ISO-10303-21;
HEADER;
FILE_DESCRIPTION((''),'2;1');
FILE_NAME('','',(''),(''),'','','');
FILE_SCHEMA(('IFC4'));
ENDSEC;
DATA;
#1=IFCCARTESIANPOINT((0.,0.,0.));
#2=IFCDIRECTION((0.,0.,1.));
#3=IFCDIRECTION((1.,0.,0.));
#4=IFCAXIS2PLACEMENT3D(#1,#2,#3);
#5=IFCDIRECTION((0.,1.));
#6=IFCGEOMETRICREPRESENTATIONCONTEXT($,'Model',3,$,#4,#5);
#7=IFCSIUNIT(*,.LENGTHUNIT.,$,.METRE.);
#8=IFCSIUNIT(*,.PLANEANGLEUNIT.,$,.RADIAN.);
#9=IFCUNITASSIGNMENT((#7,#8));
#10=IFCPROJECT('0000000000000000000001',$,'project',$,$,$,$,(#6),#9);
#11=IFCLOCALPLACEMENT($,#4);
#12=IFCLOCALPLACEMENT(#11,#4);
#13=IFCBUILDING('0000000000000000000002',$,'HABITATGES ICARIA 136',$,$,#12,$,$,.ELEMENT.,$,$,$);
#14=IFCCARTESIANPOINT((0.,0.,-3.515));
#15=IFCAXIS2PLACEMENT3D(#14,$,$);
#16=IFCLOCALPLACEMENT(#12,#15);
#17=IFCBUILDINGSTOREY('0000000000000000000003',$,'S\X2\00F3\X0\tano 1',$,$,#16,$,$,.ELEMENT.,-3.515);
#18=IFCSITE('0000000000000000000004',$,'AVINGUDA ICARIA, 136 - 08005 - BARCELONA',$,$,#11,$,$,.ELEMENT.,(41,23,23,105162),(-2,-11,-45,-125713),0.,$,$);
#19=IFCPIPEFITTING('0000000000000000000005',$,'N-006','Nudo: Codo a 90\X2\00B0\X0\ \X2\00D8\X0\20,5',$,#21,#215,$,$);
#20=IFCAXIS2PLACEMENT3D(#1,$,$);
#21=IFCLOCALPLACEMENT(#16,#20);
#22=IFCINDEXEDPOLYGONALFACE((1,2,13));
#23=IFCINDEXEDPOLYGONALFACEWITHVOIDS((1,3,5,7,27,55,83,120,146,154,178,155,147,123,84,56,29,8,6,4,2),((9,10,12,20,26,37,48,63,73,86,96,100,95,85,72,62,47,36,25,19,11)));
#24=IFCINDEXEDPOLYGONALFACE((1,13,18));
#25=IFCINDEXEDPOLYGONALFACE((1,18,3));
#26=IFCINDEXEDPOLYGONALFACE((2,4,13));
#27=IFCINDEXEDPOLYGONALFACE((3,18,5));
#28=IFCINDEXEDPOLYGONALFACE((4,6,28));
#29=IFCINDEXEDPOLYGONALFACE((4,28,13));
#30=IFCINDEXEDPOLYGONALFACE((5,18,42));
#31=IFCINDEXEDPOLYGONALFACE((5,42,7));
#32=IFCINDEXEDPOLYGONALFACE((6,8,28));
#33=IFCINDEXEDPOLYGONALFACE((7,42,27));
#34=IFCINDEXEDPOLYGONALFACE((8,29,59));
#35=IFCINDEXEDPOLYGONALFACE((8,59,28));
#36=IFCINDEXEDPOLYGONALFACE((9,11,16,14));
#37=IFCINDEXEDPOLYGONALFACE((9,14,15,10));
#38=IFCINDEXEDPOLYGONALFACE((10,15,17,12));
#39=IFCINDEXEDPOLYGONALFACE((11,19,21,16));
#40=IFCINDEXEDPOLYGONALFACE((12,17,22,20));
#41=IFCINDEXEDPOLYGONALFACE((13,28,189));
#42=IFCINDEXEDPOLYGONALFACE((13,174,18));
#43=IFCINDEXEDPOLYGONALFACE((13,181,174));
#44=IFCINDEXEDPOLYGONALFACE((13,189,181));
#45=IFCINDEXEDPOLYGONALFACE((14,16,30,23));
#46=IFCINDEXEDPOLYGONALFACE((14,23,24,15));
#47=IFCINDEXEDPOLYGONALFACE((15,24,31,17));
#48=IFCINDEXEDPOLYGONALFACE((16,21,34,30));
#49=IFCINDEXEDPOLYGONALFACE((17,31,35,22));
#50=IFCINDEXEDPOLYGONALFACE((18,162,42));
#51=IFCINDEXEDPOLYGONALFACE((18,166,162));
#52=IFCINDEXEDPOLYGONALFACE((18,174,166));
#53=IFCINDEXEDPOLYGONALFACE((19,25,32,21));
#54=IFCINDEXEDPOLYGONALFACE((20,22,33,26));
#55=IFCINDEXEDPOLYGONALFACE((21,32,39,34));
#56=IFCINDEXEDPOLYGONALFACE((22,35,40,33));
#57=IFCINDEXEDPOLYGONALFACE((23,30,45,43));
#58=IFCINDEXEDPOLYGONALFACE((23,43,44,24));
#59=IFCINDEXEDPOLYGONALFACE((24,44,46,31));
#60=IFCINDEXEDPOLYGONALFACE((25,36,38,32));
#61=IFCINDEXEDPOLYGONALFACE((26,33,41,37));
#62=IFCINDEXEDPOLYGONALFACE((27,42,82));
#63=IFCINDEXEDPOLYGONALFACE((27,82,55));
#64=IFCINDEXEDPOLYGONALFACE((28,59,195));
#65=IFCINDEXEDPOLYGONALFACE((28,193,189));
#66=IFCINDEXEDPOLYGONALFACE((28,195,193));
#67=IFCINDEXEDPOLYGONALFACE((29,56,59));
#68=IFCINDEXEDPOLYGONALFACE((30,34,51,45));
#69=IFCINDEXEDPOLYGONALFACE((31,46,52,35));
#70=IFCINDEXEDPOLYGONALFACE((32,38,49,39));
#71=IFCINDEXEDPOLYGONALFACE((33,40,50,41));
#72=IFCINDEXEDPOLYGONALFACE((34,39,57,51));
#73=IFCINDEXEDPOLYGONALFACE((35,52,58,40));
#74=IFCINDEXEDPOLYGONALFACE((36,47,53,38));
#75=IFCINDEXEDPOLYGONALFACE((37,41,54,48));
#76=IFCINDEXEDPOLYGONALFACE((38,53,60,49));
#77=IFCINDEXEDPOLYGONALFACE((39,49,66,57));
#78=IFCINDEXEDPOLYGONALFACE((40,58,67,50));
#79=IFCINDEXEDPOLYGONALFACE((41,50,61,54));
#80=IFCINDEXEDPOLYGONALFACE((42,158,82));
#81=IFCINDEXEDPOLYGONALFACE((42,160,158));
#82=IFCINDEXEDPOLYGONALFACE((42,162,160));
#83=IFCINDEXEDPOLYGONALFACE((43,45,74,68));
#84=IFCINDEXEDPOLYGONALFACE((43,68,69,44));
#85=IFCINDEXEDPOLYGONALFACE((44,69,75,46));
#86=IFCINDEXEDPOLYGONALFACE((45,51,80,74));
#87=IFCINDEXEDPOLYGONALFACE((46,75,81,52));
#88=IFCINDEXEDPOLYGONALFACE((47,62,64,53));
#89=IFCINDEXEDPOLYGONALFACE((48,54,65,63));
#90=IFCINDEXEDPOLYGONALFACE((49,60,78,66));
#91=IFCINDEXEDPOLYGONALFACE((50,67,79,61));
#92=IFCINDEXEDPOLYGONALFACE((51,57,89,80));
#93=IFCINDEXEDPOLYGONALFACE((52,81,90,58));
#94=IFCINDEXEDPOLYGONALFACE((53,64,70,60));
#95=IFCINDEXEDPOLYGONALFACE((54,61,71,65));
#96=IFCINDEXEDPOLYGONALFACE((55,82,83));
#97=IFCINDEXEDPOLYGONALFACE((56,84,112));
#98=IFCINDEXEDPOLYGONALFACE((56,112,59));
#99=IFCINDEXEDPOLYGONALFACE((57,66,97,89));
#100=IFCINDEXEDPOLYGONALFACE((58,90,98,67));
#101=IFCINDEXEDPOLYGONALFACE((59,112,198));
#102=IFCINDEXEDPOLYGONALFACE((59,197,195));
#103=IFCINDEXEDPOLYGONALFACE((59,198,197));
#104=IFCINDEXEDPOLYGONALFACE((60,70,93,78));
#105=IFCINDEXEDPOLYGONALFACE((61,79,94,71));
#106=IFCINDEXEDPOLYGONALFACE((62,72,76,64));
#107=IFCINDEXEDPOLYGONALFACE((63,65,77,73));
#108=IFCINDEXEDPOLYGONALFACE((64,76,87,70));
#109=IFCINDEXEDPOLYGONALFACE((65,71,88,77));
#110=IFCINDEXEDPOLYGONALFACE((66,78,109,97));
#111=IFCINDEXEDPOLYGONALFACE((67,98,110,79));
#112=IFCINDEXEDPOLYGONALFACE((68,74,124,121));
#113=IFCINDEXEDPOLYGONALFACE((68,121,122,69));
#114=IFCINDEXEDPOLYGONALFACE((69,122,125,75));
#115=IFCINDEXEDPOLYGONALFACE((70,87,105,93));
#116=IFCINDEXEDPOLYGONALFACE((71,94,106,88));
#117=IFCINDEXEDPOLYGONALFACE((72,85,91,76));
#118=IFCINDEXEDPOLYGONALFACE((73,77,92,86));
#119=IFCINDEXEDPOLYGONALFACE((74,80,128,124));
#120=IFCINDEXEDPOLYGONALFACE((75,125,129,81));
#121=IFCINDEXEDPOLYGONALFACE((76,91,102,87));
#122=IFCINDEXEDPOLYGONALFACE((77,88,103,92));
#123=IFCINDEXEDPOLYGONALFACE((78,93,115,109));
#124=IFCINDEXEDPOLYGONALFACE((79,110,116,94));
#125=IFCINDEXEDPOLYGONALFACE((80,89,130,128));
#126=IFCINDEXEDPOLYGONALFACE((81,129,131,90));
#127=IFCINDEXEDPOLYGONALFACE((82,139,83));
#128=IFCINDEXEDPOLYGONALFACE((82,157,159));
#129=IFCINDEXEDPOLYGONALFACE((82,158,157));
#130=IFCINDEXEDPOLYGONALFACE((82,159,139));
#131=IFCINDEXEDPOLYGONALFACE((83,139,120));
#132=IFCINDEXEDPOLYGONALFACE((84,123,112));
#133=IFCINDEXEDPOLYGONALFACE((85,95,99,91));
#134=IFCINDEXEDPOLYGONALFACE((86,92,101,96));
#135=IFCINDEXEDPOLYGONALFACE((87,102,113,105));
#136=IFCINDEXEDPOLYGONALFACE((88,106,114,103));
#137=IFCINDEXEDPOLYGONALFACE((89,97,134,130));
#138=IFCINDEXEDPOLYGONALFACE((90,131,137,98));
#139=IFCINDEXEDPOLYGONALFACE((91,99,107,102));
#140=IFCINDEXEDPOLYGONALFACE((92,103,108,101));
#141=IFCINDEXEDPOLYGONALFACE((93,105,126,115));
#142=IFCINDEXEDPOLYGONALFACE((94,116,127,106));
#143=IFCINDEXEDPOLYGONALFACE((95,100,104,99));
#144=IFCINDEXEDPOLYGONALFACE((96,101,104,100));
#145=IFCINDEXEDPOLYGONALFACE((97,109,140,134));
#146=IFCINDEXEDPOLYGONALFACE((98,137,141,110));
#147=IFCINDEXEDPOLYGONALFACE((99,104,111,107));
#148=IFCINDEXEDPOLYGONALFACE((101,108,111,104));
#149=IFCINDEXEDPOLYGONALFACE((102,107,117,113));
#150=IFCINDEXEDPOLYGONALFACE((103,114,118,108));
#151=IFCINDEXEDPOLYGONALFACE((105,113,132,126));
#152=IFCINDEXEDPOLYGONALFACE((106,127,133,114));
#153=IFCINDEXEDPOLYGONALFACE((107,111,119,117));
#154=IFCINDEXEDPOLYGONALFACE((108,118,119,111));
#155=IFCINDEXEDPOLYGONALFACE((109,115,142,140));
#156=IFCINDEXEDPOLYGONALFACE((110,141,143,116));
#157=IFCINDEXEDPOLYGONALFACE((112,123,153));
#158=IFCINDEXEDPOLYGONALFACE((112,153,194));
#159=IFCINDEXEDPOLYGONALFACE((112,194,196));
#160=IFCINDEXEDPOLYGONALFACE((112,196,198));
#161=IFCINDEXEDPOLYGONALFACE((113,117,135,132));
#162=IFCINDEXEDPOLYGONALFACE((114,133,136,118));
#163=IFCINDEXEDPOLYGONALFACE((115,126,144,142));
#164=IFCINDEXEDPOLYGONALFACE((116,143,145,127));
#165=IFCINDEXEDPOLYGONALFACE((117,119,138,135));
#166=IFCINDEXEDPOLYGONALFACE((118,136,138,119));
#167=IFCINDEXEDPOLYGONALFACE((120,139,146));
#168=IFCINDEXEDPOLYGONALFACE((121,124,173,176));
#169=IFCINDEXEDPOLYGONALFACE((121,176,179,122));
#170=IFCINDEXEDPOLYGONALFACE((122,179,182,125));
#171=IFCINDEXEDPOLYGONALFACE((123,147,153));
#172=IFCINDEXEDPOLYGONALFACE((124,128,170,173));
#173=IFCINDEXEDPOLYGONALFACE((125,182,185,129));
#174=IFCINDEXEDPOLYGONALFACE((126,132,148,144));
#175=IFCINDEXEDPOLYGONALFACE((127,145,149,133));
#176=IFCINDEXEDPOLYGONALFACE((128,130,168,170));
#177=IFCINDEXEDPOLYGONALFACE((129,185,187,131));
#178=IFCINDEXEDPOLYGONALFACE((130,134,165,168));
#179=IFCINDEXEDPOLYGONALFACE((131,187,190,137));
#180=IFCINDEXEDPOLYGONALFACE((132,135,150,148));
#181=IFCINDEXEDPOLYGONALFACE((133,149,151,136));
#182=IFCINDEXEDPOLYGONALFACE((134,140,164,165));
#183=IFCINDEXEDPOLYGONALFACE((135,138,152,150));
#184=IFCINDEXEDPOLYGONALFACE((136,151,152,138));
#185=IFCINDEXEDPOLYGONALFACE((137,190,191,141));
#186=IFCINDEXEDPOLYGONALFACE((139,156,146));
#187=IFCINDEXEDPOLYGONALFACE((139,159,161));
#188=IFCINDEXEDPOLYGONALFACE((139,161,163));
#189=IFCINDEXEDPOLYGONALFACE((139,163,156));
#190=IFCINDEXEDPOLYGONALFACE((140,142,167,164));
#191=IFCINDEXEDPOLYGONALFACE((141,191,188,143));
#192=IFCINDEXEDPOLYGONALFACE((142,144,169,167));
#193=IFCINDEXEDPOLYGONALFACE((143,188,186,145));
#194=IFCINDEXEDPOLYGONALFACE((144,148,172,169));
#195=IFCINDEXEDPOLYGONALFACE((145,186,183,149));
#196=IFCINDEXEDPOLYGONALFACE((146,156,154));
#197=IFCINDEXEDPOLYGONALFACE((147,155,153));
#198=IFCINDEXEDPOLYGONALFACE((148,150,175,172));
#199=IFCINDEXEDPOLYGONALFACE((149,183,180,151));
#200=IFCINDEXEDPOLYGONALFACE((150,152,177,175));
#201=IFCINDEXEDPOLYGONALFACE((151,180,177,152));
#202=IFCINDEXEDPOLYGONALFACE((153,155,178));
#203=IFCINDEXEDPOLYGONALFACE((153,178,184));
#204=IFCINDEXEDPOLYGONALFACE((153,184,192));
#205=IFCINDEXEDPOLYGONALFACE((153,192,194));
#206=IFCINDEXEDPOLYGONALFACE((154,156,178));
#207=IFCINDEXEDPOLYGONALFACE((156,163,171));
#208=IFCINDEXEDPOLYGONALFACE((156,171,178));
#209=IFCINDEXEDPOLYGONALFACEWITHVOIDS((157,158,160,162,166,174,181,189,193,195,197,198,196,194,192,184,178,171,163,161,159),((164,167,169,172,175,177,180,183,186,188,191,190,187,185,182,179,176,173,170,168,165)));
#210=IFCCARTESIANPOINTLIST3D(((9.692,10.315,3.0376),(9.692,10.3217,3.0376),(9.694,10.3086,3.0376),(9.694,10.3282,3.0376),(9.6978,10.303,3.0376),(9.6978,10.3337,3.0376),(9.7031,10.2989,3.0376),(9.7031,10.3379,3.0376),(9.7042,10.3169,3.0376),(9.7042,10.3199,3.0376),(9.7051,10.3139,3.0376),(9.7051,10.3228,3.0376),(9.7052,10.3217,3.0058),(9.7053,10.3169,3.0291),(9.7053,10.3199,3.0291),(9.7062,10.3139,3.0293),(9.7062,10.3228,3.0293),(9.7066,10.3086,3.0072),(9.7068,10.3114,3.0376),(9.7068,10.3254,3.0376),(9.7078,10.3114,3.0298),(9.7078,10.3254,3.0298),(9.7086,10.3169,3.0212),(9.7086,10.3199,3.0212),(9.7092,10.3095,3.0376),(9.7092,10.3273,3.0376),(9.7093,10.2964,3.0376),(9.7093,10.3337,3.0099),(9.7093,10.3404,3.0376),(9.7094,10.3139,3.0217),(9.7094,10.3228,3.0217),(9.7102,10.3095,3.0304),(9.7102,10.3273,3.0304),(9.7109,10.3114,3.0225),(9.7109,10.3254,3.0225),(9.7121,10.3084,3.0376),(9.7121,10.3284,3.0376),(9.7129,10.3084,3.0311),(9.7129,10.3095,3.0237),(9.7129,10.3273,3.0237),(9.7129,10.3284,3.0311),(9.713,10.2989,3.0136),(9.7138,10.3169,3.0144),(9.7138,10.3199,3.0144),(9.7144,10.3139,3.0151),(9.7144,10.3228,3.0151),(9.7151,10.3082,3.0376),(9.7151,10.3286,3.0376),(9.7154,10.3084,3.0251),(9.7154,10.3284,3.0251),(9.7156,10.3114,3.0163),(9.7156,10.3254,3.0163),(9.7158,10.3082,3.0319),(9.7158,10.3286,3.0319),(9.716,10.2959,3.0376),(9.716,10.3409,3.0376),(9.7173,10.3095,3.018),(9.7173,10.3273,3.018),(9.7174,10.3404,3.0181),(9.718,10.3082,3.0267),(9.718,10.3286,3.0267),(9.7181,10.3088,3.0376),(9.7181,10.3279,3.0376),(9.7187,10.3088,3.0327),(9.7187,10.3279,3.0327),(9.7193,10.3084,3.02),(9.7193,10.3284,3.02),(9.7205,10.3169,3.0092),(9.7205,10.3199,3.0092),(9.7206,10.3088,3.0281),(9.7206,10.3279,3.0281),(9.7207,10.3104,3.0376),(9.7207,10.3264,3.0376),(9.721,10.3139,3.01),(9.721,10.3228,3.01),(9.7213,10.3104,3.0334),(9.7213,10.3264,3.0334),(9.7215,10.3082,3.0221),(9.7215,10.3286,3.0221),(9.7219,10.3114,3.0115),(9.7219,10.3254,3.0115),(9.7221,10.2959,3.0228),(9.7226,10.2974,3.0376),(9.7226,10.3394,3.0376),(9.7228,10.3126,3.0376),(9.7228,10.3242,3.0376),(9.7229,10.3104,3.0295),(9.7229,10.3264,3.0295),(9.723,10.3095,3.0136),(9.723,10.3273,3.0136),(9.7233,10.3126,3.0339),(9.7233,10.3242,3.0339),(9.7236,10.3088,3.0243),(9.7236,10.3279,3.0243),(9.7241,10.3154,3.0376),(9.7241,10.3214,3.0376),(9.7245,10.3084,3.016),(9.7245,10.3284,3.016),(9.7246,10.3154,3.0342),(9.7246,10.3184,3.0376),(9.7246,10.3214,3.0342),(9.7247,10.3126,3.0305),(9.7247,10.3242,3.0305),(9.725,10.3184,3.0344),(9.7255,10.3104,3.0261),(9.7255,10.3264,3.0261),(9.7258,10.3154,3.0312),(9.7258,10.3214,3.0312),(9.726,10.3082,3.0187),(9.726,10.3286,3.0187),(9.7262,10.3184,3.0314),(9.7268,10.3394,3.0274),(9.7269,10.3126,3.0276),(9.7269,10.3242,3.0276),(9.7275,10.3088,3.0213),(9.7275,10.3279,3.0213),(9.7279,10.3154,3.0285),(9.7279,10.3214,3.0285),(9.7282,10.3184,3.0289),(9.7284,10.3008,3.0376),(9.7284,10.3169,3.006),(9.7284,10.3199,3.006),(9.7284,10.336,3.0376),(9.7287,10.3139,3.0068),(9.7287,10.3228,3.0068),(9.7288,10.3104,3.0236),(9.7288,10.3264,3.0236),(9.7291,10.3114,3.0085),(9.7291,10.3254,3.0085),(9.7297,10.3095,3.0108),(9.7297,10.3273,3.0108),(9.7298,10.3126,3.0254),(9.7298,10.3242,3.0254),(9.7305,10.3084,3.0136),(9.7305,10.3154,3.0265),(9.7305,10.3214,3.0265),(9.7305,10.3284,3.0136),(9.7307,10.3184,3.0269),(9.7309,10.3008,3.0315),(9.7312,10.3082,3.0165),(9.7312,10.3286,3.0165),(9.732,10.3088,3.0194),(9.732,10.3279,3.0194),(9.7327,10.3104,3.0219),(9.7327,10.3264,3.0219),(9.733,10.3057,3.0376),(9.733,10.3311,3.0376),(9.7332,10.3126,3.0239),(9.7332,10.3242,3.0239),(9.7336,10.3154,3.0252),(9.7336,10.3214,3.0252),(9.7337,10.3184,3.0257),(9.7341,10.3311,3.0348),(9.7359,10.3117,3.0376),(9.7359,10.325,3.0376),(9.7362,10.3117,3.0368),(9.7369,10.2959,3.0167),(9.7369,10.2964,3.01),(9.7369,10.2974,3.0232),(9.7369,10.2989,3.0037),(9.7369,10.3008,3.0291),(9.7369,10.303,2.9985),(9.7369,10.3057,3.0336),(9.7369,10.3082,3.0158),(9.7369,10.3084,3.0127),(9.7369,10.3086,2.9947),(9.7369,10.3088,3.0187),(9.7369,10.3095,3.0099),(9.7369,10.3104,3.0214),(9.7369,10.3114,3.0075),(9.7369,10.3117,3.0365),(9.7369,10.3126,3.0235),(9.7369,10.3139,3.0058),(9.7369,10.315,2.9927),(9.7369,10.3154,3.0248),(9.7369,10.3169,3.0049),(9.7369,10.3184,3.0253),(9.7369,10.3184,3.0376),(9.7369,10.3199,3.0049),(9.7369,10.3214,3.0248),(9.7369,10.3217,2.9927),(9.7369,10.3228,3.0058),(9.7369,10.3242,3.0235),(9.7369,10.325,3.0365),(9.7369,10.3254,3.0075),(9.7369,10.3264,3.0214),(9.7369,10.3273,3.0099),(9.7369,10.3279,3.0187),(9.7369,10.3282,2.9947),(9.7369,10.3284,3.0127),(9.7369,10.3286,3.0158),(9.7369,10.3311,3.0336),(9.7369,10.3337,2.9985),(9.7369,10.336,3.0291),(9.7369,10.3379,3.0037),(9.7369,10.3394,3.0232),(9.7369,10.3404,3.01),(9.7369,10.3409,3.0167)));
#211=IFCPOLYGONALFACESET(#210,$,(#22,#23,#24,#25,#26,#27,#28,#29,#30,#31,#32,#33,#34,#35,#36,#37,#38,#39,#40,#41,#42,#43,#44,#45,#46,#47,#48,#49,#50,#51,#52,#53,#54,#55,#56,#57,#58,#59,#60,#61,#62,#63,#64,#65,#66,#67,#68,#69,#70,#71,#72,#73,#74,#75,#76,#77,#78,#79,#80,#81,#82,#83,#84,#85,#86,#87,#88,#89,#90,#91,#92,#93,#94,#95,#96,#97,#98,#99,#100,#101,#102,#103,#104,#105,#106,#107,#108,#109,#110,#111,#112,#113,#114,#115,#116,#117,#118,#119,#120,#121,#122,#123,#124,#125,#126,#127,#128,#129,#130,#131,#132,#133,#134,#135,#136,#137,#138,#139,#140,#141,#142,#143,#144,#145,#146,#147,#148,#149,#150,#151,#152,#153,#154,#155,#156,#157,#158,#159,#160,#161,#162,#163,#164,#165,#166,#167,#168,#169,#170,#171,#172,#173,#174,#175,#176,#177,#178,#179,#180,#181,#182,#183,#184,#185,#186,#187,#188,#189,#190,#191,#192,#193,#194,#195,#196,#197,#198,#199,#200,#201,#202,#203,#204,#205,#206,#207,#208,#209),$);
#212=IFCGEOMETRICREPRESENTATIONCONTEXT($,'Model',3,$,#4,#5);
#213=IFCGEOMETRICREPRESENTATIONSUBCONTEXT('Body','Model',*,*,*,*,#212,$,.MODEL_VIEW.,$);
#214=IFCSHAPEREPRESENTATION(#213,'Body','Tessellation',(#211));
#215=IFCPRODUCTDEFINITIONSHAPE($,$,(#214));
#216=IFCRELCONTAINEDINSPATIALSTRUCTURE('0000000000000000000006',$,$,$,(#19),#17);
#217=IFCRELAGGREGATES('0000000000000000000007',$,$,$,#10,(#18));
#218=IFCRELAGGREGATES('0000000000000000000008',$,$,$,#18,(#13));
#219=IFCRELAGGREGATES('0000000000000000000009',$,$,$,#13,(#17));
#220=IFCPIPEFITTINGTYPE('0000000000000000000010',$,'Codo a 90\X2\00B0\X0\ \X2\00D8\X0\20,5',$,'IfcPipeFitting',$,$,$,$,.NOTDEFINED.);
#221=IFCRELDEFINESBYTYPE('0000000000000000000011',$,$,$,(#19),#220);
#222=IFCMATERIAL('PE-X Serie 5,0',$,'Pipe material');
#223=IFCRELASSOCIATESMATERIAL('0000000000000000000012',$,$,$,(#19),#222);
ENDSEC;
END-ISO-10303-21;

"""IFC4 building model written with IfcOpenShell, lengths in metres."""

from ifc_helpers import new_model, entity, si_unit, direction, frame, origin_with_axes, place, context, subcontext, project, spatial, source, transform, mapped, material, type_object, element, save


model = new_model("IFC4")

# Units and contexts
model_context_1 = context("Model", 3, world=origin_with_axes(), true_north=direction((0.0, 1.0)))
model_context_2 = context("Model", 3, world=origin_with_axes(), true_north=direction((0.0, 1.0)))
body_context_1 = subcontext(model_context_2, "Body", "Model", "MODEL_VIEW")
ifc_project = project(units=[si_unit("LENGTHUNIT", "METRE"), si_unit("PLANEANGLEUNIT", "RADIAN")], contexts=[model_context_1])

# Site, building, storey
site_placement = place(None, origin_with_axes())
site = spatial("IfcSite", under=ifc_project, at=site_placement, Name="AVINGUDA ICARIA, 136 - 08005 - BARCELONA", CompositionType="ELEMENT", RefLatitude=(41, 23, 23, 105162), RefLongitude=(-2, -11, -45, -125713), RefElevation=0.0)
building_placement = place(site_placement, origin_with_axes())
building = spatial("IfcBuilding", under=site, at=building_placement, Name="HABITATGES ICARIA 136", CompositionType="ELEMENT")
storey_placement = place(building_placement, frame((0.0, 0.0, -3.515)))
storey = spatial("IfcBuildingStorey", under=building, at=storey_placement, Name="Sótano 1", CompositionType="ELEMENT", Elevation=-3.515)

# Shared definitions
ifc_material_1 = material(Name="PE-X Serie 5,0", Category="Pipe material")
placement_1 = place(None, origin_with_axes())
placement_2 = place(placement_1, origin_with_axes())
placement_3 = place(placement_2, frame((0.0, 0.0, -3.515)))

# Pipe fitting
pipe_fitting_type_1 = type_object("IfcPipeFittingType", Name="Codo a 90° Ø20,5", ApplicableOccurrence="IfcPipeFitting", PredefinedType="NOTDEFINED")
shared_shape_1 = source(origin_with_axes(), body_context_1, "Body", "SweptSolid", [
    entity("IfcRevolvedAreaSolid", entity("IfcCircleHollowProfileDef", "AREA", None, entity("IfcAxis2Placement2D", entity("IfcCartesianPoint", [0.0, 0.0]), entity("IfcDirection", [1.0, 0.0])), 0.0226, 0.0123), entity("IfcAxis2Placement3D", entity("IfcCartesianPoint", [0.0226, 0.0, 0.0]), entity("IfcDirection", [-1.0, 0.0, 0.0]), entity("IfcDirection", [0.0, -1.0, 0.0])), entity("IfcAxis1Placement", entity("IfcCartesianPoint", [0.0226, 0.0, 0.0]), entity("IfcDirection", [0.0, 1.0, 0.0])), 1.570796),
])
pipe_fitting_1_placement = place(placement_3, origin_with_axes())
element("IfcPipeFitting", 1, at=pipe_fitting_1_placement, inside=storey, type_object=pipe_fitting_type_1, material=ifc_material_1, Name="N-006", Description="Nudo: Codo a 90° Ø20,5", context=body_context_1, shape_type="MappedRepresentation", body=[
    mapped(shared_shape_1, transform((9.7143, 10.3184, 3.015), x_axis=(1.0, 0.0, 0.0), y_axis=(0.0, 0.0, -1.0), z_axis=(0.0, 1.0, 0.0), scale=1.0)),
])

save(model, "model.ifc")
